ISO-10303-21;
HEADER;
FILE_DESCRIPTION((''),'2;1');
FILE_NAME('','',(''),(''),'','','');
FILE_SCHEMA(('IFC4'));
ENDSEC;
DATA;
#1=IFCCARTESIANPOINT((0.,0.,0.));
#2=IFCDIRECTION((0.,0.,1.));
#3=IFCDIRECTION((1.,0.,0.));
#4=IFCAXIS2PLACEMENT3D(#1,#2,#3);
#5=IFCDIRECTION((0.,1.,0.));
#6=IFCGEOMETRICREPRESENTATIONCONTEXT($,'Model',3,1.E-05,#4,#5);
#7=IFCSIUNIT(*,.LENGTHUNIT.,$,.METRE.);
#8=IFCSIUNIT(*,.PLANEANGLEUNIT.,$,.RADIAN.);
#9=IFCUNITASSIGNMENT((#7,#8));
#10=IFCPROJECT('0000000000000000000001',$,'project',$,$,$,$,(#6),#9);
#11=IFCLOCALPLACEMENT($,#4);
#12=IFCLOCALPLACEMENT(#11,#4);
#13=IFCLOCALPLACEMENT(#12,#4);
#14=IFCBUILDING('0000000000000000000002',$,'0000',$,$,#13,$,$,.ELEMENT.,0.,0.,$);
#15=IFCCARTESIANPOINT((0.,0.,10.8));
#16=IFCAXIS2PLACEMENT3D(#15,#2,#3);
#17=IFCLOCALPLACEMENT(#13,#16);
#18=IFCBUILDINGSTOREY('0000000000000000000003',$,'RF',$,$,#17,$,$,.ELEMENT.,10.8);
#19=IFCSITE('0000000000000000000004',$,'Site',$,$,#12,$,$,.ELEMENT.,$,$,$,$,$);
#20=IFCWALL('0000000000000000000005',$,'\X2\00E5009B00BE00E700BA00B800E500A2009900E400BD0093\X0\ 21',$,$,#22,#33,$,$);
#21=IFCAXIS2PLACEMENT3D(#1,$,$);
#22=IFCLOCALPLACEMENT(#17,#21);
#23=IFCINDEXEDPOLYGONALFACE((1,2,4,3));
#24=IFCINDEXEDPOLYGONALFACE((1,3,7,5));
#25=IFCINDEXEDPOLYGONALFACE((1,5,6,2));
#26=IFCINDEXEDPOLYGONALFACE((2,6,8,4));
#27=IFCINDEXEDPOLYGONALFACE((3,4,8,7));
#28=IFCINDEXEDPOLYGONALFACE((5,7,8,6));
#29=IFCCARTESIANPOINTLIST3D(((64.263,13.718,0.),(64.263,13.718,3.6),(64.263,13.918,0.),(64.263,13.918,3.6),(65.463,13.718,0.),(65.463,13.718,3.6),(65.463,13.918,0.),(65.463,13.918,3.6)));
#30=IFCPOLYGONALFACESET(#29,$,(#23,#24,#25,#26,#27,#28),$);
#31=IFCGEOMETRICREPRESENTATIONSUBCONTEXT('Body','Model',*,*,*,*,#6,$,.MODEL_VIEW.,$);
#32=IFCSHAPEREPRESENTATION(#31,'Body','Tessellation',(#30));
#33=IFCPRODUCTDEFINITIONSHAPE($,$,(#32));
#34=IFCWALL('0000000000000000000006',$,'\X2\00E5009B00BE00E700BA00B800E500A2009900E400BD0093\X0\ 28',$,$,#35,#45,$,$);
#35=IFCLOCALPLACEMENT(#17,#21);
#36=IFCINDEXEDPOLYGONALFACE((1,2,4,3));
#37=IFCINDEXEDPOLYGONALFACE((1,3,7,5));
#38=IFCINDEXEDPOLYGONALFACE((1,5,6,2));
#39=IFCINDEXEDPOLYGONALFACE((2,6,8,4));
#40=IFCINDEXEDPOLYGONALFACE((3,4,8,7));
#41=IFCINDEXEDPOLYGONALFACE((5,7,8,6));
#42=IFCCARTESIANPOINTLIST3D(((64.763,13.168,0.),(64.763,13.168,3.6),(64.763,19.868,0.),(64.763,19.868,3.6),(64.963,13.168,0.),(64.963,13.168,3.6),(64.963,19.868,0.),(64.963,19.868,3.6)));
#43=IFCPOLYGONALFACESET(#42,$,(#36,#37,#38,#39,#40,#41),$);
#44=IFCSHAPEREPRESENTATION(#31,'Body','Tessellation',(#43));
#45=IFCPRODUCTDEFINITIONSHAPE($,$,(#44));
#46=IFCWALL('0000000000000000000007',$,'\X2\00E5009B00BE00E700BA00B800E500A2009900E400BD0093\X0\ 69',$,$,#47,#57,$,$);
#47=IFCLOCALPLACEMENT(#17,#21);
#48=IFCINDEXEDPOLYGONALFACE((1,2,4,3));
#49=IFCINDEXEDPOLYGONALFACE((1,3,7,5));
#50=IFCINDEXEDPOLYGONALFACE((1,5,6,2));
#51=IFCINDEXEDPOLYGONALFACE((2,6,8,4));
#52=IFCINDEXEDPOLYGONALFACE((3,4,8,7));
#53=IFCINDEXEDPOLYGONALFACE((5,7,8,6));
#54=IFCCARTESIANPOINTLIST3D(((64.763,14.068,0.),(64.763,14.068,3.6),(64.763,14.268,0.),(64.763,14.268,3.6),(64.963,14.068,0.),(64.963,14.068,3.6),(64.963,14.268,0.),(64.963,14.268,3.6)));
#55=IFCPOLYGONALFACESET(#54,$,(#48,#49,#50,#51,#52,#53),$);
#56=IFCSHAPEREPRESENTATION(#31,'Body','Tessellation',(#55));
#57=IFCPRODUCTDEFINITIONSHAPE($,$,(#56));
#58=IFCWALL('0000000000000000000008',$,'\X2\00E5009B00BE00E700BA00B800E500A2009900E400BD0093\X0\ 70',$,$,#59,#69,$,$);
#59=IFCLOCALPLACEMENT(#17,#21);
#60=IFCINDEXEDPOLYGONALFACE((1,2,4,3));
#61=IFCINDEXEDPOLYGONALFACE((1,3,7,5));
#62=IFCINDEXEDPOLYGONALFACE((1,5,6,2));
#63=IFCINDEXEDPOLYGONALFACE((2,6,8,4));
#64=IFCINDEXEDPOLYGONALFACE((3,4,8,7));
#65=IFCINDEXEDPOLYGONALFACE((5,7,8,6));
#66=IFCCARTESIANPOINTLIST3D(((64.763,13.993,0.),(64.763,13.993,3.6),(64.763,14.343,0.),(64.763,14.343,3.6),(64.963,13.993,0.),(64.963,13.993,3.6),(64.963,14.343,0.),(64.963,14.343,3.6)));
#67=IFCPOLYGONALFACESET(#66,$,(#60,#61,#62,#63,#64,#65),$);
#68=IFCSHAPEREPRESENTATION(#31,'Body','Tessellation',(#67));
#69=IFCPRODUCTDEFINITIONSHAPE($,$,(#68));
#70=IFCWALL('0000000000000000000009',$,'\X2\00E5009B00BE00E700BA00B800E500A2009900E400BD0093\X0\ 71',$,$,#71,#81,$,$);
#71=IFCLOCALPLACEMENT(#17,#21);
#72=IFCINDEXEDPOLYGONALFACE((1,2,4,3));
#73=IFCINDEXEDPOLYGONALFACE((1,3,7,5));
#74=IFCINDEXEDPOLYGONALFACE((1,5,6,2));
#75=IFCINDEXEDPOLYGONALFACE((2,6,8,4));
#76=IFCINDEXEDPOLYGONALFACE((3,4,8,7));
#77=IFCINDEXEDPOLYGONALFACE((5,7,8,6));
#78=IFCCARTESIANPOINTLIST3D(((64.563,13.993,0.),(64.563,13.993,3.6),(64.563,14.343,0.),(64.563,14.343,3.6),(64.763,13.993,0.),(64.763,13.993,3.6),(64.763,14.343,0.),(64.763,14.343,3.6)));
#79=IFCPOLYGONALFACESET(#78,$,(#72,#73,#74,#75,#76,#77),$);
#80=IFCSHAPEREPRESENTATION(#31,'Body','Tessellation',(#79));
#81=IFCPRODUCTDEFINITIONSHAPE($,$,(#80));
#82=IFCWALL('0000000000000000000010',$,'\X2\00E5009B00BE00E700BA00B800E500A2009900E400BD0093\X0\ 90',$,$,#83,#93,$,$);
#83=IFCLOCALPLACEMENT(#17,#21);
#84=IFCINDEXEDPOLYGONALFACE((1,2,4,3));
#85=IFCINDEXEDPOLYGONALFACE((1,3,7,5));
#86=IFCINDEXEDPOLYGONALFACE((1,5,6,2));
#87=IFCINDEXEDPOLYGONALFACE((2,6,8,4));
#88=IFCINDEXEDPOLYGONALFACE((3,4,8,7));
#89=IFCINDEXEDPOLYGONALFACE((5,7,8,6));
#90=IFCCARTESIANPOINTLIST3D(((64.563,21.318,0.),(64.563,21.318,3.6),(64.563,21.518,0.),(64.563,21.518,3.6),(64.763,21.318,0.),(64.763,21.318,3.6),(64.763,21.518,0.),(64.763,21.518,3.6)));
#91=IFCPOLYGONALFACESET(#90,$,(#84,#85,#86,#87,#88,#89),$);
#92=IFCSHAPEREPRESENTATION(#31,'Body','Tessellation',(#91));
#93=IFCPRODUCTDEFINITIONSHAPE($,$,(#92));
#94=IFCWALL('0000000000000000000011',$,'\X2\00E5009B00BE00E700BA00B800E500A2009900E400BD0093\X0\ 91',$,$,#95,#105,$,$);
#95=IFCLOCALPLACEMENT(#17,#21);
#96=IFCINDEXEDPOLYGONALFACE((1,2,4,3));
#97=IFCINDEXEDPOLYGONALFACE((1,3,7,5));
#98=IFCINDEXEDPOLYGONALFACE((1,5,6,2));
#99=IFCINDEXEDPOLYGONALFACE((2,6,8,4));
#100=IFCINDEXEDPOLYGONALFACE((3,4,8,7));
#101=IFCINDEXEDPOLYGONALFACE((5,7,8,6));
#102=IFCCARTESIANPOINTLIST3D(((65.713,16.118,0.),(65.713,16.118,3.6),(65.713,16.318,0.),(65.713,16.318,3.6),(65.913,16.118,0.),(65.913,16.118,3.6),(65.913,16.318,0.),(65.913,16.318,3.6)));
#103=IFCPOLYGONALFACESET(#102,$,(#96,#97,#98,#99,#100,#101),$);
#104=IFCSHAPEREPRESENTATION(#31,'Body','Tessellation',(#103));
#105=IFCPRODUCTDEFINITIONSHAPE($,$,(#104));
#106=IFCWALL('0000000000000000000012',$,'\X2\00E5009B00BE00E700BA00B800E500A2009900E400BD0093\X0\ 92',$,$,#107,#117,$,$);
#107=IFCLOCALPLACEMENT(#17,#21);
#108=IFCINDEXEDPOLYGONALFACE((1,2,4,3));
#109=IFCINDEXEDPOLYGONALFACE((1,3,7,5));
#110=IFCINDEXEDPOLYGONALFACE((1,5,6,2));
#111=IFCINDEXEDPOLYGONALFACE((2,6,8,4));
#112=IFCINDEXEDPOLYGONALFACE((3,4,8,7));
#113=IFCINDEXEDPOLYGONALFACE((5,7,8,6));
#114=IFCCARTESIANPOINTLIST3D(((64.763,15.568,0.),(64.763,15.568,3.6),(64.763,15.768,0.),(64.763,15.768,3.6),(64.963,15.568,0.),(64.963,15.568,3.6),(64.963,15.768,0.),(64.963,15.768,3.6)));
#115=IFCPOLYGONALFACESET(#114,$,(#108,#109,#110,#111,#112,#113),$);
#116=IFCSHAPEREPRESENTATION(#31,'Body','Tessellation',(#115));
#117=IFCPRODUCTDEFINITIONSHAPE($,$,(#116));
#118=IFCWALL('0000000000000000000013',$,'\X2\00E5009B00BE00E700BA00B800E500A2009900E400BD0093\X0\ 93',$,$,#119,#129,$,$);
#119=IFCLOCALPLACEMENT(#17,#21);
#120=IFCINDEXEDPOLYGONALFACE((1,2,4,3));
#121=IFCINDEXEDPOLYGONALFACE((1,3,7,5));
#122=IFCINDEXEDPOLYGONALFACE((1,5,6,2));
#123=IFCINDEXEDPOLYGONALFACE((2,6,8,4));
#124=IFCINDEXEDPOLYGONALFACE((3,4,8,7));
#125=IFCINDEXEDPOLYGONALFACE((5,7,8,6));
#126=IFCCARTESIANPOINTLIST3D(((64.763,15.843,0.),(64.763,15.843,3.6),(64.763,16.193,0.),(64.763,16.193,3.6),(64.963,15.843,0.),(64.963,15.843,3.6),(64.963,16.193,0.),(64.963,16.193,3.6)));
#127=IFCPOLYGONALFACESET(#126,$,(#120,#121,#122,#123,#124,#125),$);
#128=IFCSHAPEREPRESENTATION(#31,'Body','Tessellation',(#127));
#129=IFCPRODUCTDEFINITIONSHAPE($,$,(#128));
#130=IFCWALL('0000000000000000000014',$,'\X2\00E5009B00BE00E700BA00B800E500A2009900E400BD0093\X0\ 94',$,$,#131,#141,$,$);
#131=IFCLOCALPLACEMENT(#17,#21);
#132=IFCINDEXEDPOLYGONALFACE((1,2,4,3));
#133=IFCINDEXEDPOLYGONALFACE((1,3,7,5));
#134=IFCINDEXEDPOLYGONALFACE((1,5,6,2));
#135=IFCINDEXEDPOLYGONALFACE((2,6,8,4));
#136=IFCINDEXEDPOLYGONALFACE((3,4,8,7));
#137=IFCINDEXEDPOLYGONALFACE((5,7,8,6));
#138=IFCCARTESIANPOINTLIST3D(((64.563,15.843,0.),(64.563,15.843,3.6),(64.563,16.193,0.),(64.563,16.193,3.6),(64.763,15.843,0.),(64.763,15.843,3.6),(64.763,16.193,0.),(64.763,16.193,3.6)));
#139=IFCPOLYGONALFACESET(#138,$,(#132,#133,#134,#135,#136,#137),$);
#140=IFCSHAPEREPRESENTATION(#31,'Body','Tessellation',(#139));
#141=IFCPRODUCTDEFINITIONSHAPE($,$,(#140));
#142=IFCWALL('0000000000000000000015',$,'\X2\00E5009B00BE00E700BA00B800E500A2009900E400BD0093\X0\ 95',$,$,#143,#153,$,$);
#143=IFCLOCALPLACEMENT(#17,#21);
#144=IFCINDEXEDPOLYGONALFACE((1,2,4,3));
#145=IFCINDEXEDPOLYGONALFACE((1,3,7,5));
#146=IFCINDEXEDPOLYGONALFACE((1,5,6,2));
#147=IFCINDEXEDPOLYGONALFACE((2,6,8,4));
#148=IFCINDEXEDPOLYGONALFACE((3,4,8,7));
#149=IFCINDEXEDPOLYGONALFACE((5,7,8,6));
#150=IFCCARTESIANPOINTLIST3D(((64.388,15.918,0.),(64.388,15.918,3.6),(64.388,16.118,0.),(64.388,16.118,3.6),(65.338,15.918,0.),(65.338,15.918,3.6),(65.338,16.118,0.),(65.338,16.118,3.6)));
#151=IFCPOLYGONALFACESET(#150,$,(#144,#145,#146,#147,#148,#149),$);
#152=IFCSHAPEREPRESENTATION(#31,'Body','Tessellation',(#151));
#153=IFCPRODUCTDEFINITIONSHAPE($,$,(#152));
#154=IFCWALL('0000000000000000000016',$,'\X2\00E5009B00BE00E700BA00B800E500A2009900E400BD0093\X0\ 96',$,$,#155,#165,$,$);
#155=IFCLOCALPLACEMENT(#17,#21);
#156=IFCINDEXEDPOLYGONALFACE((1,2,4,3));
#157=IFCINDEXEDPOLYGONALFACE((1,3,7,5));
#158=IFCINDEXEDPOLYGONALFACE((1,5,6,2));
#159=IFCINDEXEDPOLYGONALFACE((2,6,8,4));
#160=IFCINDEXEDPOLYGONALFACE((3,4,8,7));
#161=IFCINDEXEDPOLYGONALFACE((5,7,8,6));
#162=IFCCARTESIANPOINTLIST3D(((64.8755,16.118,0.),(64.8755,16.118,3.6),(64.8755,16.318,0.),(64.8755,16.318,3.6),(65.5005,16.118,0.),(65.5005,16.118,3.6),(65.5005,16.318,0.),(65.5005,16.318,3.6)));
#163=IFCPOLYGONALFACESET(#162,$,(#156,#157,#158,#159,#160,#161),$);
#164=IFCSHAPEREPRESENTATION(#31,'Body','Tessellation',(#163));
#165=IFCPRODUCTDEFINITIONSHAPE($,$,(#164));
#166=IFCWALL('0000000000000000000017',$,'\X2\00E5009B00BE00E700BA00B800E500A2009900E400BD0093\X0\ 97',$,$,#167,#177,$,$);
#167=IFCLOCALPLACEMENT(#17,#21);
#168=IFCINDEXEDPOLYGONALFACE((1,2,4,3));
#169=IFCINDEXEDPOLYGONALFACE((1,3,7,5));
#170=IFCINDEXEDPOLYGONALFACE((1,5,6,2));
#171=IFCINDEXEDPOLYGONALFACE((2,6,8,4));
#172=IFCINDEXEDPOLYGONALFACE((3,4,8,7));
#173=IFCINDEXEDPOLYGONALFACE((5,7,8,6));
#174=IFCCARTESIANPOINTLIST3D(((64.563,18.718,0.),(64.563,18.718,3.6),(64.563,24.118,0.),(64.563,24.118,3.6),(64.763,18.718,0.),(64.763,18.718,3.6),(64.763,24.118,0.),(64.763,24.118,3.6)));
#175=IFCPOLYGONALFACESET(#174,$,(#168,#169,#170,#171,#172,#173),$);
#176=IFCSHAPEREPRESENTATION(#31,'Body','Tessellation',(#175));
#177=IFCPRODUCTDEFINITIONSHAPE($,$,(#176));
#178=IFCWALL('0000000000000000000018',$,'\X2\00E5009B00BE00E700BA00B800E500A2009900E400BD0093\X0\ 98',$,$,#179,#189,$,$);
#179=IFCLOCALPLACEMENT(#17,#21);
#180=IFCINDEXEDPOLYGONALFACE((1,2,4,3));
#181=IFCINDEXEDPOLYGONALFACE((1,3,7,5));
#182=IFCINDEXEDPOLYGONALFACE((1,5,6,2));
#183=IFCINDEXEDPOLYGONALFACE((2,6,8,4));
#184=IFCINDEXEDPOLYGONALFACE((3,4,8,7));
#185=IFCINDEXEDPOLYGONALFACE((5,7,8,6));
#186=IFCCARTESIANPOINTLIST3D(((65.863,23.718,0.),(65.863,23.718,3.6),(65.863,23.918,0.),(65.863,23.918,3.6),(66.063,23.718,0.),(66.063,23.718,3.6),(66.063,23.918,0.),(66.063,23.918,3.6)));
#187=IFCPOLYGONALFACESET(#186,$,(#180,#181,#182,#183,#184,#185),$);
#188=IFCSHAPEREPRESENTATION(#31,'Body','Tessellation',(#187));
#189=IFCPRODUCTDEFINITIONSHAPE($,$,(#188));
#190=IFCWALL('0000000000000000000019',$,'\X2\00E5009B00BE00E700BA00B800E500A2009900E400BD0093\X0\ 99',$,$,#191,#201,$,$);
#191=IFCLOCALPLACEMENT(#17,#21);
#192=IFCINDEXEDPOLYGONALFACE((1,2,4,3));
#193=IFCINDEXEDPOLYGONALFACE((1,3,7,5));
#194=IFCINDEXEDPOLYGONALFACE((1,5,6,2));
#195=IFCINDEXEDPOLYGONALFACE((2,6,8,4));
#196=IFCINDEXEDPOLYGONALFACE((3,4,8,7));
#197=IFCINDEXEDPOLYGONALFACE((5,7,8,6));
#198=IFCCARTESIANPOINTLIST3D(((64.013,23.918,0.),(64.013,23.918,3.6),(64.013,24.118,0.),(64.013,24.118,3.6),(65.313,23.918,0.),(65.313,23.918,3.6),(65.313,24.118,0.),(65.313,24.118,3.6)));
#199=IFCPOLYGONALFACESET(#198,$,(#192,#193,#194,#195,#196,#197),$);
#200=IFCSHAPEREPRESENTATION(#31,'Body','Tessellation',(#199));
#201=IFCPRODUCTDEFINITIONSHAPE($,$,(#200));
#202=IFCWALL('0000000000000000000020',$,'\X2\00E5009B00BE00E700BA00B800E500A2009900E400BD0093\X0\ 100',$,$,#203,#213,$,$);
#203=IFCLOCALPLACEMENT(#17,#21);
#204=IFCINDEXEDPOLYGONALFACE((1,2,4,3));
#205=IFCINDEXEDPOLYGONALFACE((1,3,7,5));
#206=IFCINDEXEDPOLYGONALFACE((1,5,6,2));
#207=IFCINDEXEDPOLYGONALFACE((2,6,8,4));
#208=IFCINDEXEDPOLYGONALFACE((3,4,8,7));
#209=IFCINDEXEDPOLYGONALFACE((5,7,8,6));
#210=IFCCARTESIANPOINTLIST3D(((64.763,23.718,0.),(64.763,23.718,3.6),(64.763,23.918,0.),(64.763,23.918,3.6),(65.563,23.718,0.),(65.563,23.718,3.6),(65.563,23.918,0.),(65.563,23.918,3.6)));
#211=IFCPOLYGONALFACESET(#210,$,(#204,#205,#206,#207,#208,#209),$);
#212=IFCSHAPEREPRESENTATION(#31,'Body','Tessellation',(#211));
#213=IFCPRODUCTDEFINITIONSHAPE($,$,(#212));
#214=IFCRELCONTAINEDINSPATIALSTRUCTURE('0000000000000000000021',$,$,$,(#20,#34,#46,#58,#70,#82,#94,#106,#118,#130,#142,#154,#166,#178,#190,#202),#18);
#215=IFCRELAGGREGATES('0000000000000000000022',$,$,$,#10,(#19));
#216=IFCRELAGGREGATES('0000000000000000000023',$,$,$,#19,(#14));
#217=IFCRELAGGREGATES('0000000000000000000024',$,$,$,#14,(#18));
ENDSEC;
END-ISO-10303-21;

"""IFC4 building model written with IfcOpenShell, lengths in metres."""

from ifc_helpers import new_model, si_unit, direction, frame, frame_2d, origin_with_axes, place, context, subcontext, project, spatial, rectangle, extrude, element, save


model = new_model("IFC4")

# Units and contexts
model_context = context("Model", 3, precision=1e-05, world=origin_with_axes(), true_north=direction((0.0, 1.0, 0.0)))
body_context = subcontext(model_context, "Body", "Model", "MODEL_VIEW")
ifc_project = project(units=[si_unit("LENGTHUNIT", "METRE"), si_unit("PLANEANGLEUNIT", "RADIAN")], contexts=[model_context])

# Site, building, storey
placement = place(None, origin_with_axes())
site_placement = place(placement, origin_with_axes())
site = spatial("IfcSite", under=ifc_project, at=site_placement, Name="Site", CompositionType="ELEMENT")
building_placement = place(site_placement, origin_with_axes())
building = spatial("IfcBuilding", under=site, at=building_placement, Name="0000", CompositionType="ELEMENT", ElevationOfRefHeight=0.0, ElevationOfTerrain=0.0)
storey_placement = place(building_placement, frame((0.0, 0.0, 10.8), z_axis=(0.0, 0.0, 1.0), x_axis=(1.0, 0.0, 0.0)))
storey = spatial("IfcBuildingStorey", under=building, at=storey_placement, Name="RF", CompositionType="ELEMENT", Elevation=10.8)

# Walls
wall_1_placement = place(storey_placement, frame((64.863, 13.818, 0.0), z_axis=(0.0, 0.0, 1.0), x_axis=(1.0, 0.0, 0.0)))
element("IfcWall", 1, at=wall_1_placement, inside=storey, Name="å\u009b¾çº¸å¢\u0099ä½\u0093 21", context=body_context, shape_type="SweptSolid", body=[
    extrude(rectangle(XDim=1.2, YDim=0.2, at=frame_2d((0.0, 0.0), x_axis=(1.0, 0.0, 0.0))), frame((0.0, 0.0, 0.0), z_axis=(0.0, 0.0, 1.0)), (0.0, 0.0, 1.0), 3.6),
])
wall_2_placement = place(storey_placement, frame((64.863, 16.518, 0.0), z_axis=(0.0, 0.0, 1.0), x_axis=(0.0, 1.0, 0.0)))
element("IfcWall", 2, at=wall_2_placement, inside=storey, Name="å\u009b¾çº¸å¢\u0099ä½\u0093 28", context=body_context, shape_type="SweptSolid", body=[
    extrude(rectangle(XDim=6.7, YDim=0.2, at=frame_2d((0.0, 0.0), x_axis=(1.0, 0.0, 0.0))), frame((0.0, 0.0, 0.0), z_axis=(0.0, 0.0, 1.0)), (0.0, 0.0, 1.0), 3.6),
])
wall_3_placement = place(storey_placement, frame((64.863, 14.168, 0.0), z_axis=(0.0, 0.0, 1.0), x_axis=(-1.0, 0.0, 0.0)))
element("IfcWall", 3, at=wall_3_placement, inside=storey, Name="å\u009b¾çº¸å¢\u0099ä½\u0093 69", context=body_context, shape_type="SweptSolid", body=[
    extrude(rectangle(XDim=0.2, YDim=0.2, at=frame_2d((0.0, 0.0), x_axis=(1.0, 0.0, 0.0))), frame((0.0, 0.0, 0.0), z_axis=(0.0, 0.0, 1.0)), (0.0, 0.0, 1.0), 3.6),
])
for number, where, z_axis, x_axis, name in (
    (4, (64.863, 14.168, 0.0), (0.0, 0.0, 1.0), (0.0, -1.0, 0.0), "å\u009b¾çº¸å¢\u0099ä½\u0093 70"),
    (5, (64.663, 14.168, 0.0), (0.0, 0.0, 1.0), (0.0, -1.0, 0.0), "å\u009b¾çº¸å¢\u0099ä½\u0093 71"),
):
    element("IfcWall", number, at=place(storey_placement, frame(where, z_axis=z_axis, x_axis=x_axis)), inside=storey, Name=name, context=body_context, shape_type="SweptSolid", body=[
        extrude(rectangle(XDim=0.35, YDim=0.2, at=frame_2d((0.0, 0.0), x_axis=(1.0, 0.0, 0.0))), frame((0.0, 0.0, 0.0), z_axis=(0.0, 0.0, 1.0)), (0.0, 0.0, 1.0), 3.6),
    ])
for number, where, z_axis, x_axis, name in (
    (6, (64.663, 21.418, 0.0), (0.0, 0.0, 1.0), (0.0, 1.0, 0.0), "å\u009b¾çº¸å¢\u0099ä½\u0093 90"),
    (7, (65.813, 16.218, 0.0), (0.0, 0.0, 1.0), (0.0, -1.0, 0.0), "å\u009b¾çº¸å¢\u0099ä½\u0093 91"),
    (8, (64.863, 15.668, 0.0), (0.0, 0.0, 1.0), (-1.0, 0.0, 0.0), "å\u009b¾çº¸å¢\u0099ä½\u0093 92"),
):
    element("IfcWall", number, at=place(storey_placement, frame(where, z_axis=z_axis, x_axis=x_axis)), inside=storey, Name=name, context=body_context, shape_type="SweptSolid", body=[
        extrude(rectangle(XDim=0.2, YDim=0.2, at=frame_2d((0.0, 0.0), x_axis=(1.0, 0.0, 0.0))), frame((0.0, 0.0, 0.0), z_axis=(0.0, 0.0, 1.0)), (0.0, 0.0, 1.0), 3.6),
    ])
for number, where, z_axis, x_axis, name in (
    (9, (64.863, 16.018, 0.0), (0.0, 0.0, 1.0), (0.0, -1.0, 0.0), "å\u009b¾çº¸å¢\u0099ä½\u0093 93"),
    (10, (64.663, 16.018, 0.0), (0.0, 0.0, 1.0), (0.0, -1.0, 0.0), "å\u009b¾çº¸å¢\u0099ä½\u0093 94"),
):
    element("IfcWall", number, at=place(storey_placement, frame(where, z_axis=z_axis, x_axis=x_axis)), inside=storey, Name=name, context=body_context, shape_type="SweptSolid", body=[
        extrude(rectangle(XDim=0.35, YDim=0.2, at=frame_2d((0.0, 0.0), x_axis=(1.0, 0.0, 0.0))), frame((0.0, 0.0, 0.0), z_axis=(0.0, 0.0, 1.0)), (0.0, 0.0, 1.0), 3.6),
    ])
wall_4_placement = place(storey_placement, frame((64.863, 16.018, 0.0), z_axis=(0.0, 0.0, 1.0), x_axis=(1.0, 0.0, 0.0)))
element("IfcWall", 11, at=wall_4_placement, inside=storey, Name="å\u009b¾çº¸å¢\u0099ä½\u0093 95", context=body_context, shape_type="SweptSolid", body=[
    extrude(rectangle(XDim=0.95, YDim=0.2, at=frame_2d((0.0, 0.0), x_axis=(1.0, 0.0, 0.0))), frame((0.0, 0.0, 0.0), z_axis=(0.0, 0.0, 1.0)), (0.0, 0.0, 1.0), 3.6),
])
wall_5_placement = place(storey_placement, frame((65.188, 16.218, 0.0), z_axis=(0.0, 0.0, 1.0), x_axis=(1.0, 0.0, 0.0)))
element("IfcWall", 12, at=wall_5_placement, inside=storey, Name="å\u009b¾çº¸å¢\u0099ä½\u0093 96", context=body_context, shape_type="SweptSolid", body=[
    extrude(rectangle(XDim=0.625, YDim=0.2, at=frame_2d((0.0, 0.0), x_axis=(1.0, 0.0, 0.0))), frame((0.0, 0.0, 0.0), z_axis=(0.0, 0.0, 1.0)), (0.0, 0.0, 1.0), 3.6),
])
wall_6_placement = place(storey_placement, frame((64.663, 21.418, 0.0), z_axis=(0.0, 0.0, 1.0), x_axis=(0.0, -1.0, 0.0)))
element("IfcWall", 13, at=wall_6_placement, inside=storey, Name="å\u009b¾çº¸å¢\u0099ä½\u0093 97", context=body_context, shape_type="SweptSolid", body=[
    extrude(rectangle(XDim=5.4, YDim=0.2, at=frame_2d((0.0, 0.0), x_axis=(1.0, 0.0, 0.0))), frame((0.0, 0.0, 0.0), z_axis=(0.0, 0.0, 1.0)), (0.0, 0.0, 1.0), 3.6),
])
wall_7_placement = place(storey_placement, frame((65.963, 23.818, 0.0), z_axis=(0.0, 0.0, 1.0), x_axis=(0.0, 1.0, 0.0)))
element("IfcWall", 14, at=wall_7_placement, inside=storey, Name="å\u009b¾çº¸å¢\u0099ä½\u0093 98", context=body_context, shape_type="SweptSolid", body=[
    extrude(rectangle(XDim=0.2, YDim=0.2, at=frame_2d((0.0, 0.0), x_axis=(1.0, 0.0, 0.0))), frame((0.0, 0.0, 0.0), z_axis=(0.0, 0.0, 1.0)), (0.0, 0.0, 1.0), 3.6),
])
wall_8_placement = place(storey_placement, frame((64.663, 24.018, 0.0), z_axis=(0.0, 0.0, 1.0), x_axis=(1.0, 0.0, 0.0)))
element("IfcWall", 15, at=wall_8_placement, inside=storey, Name="å\u009b¾çº¸å¢\u0099ä½\u0093 99", context=body_context, shape_type="SweptSolid", body=[
    extrude(rectangle(XDim=1.3, YDim=0.2, at=frame_2d((0.0, 0.0), x_axis=(1.0, 0.0, 0.0))), frame((0.0, 0.0, 0.0), z_axis=(0.0, 0.0, 1.0)), (0.0, 0.0, 1.0), 3.6),
])
wall_9_placement = place(storey_placement, frame((65.163, 23.818, 0.0), z_axis=(0.0, 0.0, 1.0), x_axis=(1.0, 0.0, 0.0)))
element("IfcWall", 16, at=wall_9_placement, inside=storey, Name="å\u009b¾çº¸å¢\u0099ä½\u0093 100", context=body_context, shape_type="SweptSolid", body=[
    extrude(rectangle(XDim=0.8, YDim=0.2, at=frame_2d((0.0, 0.0), x_axis=(1.0, 0.0, 0.0))), frame((0.0, 0.0, 0.0), z_axis=(0.0, 0.0, 1.0)), (0.0, 0.0, 1.0), 3.6),
])

save(model, "model.ifc")
